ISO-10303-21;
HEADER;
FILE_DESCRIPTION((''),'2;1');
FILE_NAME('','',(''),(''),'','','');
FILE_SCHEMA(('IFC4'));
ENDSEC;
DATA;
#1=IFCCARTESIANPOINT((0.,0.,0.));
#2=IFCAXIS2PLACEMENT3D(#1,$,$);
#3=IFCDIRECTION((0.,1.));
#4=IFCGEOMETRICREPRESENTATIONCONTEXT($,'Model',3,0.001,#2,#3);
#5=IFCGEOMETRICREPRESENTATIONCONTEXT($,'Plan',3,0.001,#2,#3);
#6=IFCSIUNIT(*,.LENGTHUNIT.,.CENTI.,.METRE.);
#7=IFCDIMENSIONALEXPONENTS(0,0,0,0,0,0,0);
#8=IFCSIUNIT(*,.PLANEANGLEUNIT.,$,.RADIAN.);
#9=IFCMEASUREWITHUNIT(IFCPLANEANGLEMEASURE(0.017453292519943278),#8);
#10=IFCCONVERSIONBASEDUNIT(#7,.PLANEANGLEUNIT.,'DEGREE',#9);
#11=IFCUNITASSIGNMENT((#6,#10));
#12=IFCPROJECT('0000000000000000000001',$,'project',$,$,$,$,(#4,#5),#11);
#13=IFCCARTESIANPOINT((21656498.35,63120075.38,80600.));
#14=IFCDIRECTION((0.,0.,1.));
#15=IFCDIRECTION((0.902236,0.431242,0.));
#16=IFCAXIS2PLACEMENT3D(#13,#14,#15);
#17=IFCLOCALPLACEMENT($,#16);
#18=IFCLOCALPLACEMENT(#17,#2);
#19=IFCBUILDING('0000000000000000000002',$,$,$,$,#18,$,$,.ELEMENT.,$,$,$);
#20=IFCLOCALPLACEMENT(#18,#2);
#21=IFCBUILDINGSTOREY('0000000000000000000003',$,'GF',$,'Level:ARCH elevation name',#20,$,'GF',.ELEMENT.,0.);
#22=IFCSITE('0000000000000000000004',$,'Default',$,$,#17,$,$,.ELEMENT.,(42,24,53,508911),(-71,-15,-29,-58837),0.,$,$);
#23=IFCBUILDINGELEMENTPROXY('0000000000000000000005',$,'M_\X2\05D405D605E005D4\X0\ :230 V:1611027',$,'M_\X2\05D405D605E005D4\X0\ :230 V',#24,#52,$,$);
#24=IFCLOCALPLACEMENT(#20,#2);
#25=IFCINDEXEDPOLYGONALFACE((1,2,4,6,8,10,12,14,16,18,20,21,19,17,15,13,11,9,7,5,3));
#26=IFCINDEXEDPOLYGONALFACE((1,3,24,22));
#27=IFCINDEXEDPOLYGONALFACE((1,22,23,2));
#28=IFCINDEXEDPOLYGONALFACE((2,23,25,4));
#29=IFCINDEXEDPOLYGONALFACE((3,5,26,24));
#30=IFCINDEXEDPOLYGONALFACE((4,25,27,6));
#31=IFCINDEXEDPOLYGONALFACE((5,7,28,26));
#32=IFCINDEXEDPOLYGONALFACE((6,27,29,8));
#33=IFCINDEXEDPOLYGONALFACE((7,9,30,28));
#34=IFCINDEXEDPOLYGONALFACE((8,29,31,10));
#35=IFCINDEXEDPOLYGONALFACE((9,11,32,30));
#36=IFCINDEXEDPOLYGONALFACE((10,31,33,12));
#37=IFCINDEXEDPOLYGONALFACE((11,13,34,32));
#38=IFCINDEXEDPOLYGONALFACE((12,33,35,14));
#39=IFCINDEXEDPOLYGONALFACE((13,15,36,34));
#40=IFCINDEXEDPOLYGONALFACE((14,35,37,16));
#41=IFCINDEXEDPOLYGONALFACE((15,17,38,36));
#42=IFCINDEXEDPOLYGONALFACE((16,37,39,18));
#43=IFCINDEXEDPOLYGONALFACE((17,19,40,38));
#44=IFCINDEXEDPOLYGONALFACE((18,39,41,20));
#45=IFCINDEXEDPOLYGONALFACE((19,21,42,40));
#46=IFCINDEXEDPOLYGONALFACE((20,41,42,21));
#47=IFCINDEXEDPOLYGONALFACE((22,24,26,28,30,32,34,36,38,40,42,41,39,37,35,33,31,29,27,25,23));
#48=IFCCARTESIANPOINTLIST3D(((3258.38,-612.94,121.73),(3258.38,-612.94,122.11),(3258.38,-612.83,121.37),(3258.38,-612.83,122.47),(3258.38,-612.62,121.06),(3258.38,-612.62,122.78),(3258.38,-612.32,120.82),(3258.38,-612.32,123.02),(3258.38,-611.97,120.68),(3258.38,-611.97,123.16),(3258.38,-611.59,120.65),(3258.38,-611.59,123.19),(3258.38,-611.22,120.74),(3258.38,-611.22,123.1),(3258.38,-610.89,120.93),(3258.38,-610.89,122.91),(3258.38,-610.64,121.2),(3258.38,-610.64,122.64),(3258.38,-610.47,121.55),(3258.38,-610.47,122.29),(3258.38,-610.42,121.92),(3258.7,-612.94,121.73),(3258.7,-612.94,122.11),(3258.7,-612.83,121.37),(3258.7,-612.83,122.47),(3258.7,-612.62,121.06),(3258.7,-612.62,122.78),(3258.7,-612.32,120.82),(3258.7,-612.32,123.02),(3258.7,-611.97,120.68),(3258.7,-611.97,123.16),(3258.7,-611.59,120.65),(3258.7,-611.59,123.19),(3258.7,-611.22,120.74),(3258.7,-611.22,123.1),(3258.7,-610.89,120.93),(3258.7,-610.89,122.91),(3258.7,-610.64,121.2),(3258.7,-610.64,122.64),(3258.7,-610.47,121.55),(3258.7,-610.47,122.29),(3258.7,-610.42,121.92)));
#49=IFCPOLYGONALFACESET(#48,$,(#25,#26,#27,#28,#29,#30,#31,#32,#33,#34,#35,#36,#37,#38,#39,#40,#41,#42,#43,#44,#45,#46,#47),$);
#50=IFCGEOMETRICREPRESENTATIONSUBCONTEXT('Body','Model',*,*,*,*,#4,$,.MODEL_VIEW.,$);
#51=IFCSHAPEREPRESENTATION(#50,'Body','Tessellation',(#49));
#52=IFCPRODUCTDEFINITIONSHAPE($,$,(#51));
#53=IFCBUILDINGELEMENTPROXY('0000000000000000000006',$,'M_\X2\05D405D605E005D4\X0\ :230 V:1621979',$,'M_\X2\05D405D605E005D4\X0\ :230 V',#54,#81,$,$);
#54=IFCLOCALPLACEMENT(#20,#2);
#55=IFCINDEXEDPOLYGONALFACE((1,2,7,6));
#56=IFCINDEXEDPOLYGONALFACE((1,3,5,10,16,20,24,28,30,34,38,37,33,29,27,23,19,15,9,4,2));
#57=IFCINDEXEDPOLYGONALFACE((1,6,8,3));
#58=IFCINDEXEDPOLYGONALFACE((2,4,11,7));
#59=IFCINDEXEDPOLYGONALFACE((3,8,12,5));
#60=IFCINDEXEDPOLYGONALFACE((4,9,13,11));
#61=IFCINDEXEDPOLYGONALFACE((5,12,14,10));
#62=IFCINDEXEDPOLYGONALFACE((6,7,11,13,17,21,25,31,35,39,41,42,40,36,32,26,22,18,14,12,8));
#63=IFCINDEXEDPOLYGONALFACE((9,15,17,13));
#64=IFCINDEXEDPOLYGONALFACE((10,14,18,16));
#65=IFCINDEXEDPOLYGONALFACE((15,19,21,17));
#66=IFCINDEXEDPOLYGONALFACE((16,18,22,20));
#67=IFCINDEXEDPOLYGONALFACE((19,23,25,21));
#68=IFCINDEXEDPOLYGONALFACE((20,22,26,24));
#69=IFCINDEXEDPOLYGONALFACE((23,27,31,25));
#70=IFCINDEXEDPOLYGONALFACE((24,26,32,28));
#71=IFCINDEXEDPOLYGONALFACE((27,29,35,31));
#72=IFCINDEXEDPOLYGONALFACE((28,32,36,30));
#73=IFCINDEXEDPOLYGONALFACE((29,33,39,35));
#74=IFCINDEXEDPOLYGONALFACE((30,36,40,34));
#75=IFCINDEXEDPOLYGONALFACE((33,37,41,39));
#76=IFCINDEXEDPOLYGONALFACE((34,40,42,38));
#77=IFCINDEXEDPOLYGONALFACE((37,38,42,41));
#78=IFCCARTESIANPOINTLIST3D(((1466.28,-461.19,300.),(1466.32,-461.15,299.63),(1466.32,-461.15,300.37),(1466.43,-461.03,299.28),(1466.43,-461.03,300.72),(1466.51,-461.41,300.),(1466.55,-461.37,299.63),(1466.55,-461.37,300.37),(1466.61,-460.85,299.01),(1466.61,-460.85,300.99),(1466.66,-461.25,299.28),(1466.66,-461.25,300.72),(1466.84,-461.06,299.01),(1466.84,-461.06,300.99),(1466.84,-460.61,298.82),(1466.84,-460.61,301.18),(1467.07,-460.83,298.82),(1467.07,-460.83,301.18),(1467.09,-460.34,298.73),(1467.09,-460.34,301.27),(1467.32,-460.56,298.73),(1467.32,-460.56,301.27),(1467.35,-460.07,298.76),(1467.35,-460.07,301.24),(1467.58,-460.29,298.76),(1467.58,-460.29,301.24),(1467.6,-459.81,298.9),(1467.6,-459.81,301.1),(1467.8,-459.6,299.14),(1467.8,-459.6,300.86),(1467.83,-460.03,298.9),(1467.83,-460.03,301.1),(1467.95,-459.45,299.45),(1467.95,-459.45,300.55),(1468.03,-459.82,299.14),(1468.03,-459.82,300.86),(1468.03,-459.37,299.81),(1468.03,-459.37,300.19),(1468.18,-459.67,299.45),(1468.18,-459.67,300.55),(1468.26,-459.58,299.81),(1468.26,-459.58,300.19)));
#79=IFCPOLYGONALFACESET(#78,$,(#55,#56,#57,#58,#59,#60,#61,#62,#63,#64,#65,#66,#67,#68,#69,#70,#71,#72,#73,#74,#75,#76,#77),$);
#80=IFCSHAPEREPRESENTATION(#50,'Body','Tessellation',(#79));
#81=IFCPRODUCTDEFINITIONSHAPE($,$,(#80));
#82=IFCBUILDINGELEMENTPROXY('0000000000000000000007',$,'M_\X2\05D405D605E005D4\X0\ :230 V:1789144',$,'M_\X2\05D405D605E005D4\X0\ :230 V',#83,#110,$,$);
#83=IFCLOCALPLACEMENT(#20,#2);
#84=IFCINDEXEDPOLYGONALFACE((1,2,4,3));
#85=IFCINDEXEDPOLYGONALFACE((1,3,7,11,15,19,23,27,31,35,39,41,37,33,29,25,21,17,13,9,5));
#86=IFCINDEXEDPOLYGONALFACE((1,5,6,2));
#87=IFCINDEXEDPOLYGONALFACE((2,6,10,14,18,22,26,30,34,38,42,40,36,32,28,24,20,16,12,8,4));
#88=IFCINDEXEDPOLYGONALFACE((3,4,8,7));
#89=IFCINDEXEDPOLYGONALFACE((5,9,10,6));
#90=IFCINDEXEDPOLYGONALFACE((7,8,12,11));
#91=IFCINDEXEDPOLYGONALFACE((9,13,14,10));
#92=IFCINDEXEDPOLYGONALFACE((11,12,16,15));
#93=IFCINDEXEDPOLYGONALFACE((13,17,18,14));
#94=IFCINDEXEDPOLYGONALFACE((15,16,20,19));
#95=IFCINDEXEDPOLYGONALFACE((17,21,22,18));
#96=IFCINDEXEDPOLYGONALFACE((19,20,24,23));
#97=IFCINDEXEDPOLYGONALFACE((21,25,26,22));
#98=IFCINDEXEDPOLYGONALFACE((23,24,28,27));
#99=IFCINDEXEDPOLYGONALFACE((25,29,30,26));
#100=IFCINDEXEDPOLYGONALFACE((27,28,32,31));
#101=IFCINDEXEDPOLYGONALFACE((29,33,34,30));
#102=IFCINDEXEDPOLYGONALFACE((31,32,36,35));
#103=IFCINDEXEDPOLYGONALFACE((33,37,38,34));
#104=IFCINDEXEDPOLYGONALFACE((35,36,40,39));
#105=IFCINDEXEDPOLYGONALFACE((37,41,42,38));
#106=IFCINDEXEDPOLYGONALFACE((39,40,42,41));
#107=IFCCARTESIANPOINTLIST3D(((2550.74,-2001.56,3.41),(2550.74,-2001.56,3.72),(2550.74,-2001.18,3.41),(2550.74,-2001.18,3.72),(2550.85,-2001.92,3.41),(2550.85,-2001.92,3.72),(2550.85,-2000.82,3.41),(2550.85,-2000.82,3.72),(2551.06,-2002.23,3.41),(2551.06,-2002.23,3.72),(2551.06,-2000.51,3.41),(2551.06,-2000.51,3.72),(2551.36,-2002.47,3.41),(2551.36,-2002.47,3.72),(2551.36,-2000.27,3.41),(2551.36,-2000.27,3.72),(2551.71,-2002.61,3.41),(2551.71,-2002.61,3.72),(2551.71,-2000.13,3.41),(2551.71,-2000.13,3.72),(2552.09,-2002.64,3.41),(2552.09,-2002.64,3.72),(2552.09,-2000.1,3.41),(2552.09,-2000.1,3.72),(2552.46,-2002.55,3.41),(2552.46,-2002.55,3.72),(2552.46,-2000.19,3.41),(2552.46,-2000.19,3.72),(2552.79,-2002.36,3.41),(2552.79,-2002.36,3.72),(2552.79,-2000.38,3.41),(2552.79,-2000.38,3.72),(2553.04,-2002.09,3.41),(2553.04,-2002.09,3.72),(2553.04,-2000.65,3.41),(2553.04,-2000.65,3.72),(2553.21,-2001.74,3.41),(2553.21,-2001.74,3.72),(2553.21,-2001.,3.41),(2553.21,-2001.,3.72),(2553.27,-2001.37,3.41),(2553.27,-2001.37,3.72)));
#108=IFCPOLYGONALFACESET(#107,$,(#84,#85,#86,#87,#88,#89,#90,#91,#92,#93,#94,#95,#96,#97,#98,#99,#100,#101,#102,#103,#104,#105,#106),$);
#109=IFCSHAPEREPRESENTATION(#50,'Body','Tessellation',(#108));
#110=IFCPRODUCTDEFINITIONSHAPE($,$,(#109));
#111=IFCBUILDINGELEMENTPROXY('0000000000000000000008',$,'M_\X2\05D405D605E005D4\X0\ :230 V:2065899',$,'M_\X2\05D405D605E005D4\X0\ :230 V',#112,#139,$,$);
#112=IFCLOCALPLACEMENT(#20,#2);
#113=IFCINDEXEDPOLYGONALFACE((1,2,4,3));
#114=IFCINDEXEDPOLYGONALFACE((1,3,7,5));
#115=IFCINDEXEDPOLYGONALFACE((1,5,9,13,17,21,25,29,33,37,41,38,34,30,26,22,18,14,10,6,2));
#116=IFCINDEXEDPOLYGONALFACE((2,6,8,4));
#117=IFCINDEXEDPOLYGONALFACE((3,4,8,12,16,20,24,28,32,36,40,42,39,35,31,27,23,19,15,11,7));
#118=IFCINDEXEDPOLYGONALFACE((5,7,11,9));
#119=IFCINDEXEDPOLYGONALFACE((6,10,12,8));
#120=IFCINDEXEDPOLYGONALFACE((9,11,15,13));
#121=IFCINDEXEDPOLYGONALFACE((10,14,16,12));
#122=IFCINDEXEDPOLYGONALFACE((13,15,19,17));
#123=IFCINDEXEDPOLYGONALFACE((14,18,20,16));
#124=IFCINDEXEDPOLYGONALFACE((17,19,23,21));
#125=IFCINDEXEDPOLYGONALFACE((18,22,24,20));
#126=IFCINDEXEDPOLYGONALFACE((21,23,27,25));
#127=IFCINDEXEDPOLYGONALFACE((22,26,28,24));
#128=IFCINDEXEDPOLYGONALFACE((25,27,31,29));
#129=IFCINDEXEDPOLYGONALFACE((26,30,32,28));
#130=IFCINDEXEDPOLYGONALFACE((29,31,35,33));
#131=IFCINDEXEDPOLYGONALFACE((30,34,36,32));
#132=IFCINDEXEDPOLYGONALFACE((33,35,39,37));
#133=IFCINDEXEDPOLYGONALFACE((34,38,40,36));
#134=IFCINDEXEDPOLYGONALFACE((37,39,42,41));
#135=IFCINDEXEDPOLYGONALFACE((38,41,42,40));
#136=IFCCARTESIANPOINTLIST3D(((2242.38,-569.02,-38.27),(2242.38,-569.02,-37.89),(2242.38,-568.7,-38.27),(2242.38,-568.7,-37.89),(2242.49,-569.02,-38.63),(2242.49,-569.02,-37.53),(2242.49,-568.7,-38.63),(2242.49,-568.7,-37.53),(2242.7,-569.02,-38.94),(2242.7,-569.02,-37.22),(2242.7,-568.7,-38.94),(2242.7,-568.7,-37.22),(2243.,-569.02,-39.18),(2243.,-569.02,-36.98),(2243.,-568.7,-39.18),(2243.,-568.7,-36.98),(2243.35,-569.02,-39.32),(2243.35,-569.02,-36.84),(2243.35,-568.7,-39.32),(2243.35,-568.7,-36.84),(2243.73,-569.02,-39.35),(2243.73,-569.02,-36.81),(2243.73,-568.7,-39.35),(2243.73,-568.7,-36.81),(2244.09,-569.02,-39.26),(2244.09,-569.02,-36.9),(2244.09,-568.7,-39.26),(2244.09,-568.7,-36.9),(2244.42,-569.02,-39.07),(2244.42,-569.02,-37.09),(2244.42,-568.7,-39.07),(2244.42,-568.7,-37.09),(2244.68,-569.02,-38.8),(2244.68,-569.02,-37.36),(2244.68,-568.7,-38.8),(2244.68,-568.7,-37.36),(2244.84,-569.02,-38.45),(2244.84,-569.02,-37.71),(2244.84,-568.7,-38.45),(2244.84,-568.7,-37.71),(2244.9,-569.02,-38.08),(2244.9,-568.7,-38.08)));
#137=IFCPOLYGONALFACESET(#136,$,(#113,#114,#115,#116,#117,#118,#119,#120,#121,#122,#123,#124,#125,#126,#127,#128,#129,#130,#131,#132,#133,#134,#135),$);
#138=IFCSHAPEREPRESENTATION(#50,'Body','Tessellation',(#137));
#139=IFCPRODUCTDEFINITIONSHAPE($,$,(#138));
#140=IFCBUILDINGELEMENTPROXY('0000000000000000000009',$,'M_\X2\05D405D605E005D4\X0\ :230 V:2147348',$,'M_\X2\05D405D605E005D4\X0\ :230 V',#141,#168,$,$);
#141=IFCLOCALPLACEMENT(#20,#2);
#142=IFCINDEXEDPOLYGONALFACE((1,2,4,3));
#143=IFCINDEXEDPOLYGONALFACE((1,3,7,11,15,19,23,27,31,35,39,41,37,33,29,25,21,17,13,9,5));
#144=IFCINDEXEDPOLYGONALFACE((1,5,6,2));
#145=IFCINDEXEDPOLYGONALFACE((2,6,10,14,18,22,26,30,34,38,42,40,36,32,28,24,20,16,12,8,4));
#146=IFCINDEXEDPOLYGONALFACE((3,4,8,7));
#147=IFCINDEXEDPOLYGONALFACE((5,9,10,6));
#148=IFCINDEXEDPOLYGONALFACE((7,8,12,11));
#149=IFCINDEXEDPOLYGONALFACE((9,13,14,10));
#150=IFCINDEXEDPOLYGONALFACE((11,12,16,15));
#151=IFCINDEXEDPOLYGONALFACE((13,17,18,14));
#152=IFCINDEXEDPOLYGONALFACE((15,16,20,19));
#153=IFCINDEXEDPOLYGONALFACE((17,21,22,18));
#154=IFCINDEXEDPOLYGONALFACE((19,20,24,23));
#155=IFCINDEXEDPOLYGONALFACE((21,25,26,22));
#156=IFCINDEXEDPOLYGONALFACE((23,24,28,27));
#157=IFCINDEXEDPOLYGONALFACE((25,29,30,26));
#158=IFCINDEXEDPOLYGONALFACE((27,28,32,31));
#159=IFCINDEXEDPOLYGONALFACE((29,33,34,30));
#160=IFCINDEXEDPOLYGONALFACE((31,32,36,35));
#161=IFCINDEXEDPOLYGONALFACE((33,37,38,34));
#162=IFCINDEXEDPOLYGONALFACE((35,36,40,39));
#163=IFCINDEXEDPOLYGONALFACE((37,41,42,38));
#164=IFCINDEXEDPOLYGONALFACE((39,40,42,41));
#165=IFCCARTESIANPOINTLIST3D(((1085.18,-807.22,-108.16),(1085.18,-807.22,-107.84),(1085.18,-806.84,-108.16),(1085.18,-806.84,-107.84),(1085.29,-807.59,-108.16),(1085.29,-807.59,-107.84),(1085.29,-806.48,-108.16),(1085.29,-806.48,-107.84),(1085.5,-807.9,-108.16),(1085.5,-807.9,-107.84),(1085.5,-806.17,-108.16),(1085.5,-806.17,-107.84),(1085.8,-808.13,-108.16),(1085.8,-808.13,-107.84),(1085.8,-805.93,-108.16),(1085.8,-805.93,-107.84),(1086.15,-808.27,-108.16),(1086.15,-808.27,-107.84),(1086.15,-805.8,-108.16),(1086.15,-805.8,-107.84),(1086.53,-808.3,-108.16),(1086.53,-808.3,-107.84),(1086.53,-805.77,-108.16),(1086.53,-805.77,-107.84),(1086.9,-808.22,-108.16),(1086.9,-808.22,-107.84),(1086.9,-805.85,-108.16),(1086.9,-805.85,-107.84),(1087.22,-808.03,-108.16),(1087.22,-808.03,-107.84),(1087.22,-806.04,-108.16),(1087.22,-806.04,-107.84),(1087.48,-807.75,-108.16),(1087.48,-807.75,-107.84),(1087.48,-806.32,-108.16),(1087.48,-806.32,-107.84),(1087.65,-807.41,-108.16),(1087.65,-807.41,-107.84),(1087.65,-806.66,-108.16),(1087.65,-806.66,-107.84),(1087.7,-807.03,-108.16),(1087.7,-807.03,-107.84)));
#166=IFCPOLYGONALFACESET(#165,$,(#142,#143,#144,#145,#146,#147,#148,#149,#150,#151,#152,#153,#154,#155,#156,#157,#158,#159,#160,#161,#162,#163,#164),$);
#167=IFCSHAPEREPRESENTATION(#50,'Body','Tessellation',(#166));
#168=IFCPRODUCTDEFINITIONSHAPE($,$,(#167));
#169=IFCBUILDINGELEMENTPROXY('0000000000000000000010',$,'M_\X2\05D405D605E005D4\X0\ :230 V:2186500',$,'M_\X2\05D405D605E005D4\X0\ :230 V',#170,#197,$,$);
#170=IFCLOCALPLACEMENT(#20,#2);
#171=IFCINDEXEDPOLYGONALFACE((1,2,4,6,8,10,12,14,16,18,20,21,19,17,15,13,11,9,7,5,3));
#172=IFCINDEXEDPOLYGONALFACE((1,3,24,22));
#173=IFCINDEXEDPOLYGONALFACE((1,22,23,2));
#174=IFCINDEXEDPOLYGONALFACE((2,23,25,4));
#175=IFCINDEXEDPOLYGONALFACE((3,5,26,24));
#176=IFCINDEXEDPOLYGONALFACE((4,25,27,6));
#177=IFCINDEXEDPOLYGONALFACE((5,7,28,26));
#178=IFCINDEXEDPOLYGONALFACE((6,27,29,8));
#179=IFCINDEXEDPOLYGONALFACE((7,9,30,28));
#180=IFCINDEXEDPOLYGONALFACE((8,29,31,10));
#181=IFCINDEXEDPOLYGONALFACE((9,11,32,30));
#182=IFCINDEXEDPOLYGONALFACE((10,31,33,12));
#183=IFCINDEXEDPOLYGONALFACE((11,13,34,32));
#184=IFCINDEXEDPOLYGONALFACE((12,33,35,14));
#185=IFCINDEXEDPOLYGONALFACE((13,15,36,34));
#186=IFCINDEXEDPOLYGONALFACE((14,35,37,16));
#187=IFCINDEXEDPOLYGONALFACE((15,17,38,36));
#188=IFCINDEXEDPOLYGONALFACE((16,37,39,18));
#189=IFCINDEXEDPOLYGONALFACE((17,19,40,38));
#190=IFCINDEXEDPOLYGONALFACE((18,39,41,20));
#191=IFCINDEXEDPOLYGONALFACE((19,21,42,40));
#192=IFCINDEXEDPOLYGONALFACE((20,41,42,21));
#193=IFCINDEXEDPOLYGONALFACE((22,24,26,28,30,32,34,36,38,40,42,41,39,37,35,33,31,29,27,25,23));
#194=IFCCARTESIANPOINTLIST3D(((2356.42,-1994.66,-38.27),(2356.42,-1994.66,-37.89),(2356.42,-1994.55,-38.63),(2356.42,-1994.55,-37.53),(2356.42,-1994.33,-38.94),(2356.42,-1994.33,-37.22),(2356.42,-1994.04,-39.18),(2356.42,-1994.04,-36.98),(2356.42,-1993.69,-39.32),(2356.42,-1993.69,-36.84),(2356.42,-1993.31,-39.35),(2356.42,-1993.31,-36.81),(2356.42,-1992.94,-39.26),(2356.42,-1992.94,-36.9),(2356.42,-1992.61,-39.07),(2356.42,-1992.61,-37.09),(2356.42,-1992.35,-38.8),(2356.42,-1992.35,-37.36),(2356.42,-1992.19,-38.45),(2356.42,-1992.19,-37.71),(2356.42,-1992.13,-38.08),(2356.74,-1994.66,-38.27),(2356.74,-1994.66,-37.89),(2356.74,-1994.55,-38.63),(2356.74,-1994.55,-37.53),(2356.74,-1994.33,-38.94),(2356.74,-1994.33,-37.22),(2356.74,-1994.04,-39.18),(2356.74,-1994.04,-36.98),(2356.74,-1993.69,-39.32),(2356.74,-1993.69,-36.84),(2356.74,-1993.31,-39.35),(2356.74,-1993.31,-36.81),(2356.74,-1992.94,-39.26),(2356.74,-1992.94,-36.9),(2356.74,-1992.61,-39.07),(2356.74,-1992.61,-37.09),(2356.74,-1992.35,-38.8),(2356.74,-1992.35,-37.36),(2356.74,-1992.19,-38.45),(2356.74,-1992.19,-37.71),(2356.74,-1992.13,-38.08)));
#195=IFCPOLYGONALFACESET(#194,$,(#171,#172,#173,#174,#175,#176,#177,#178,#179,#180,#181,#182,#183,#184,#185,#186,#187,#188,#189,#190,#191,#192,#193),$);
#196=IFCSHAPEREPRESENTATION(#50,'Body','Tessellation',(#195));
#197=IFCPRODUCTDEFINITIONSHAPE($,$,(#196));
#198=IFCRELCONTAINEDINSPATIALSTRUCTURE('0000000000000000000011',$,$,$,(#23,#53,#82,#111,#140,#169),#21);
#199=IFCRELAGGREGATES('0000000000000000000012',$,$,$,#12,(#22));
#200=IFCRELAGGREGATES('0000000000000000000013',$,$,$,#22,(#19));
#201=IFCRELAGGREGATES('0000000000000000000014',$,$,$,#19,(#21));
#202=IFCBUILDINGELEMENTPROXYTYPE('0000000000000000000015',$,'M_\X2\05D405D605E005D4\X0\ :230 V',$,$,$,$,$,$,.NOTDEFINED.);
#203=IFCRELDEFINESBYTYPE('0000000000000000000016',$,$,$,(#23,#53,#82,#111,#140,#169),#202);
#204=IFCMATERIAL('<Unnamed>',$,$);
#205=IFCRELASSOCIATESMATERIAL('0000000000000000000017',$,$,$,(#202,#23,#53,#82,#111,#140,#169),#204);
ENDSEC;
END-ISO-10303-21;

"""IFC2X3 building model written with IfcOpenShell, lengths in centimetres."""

from ifc_helpers import new_model, entity, si_unit, converted_unit, direction, frame, frame_2d, origin, place, context, subcontext, project, spatial, circle, extrude, source, transform, mapped, material, type_object, type_shapes, element, save


model = new_model("IFC2X3")

# Units and contexts
model_context = context("Model", 3, precision=0.001, world=origin(), true_north=direction((0.0, 1.0)))
plan_context = context("Plan", 3, precision=0.001, world=origin(), true_north=direction((0.0, 1.0)))
body_context = subcontext(model_context, "Body", "Model", "MODEL_VIEW")
ifc_project = project(units=[si_unit("LENGTHUNIT", "METRE", prefix="CENTI"), converted_unit("PLANEANGLEUNIT", "DEGREE", entity("IfcPlaneAngleMeasure", 0.017453292519943278), si_unit("PLANEANGLEUNIT", "RADIAN"), dimensions=[0, 0, 0, 0, 0, 0, 0])], contexts=[model_context, plan_context])

# Site, building, storey
site_placement = place(None, frame((21656498.35, 63120075.38, 80600.0), z_axis=(0.0, 0.0, 1.0), x_axis=(0.902236, 0.431242, 0.0)))
site = spatial("IfcSite", under=ifc_project, at=site_placement, Name="Default", CompositionType="ELEMENT", RefLatitude=(42, 24, 53, 508911), RefLongitude=(-71, -15, -29, -58837), RefElevation=0.0)
building_placement = place(site_placement, origin())
building = spatial("IfcBuilding", under=site, at=building_placement, CompositionType="ELEMENT")
storey_placement = place(building_placement, origin())
storey = spatial("IfcBuildingStorey", under=building, at=storey_placement, Name="GF", ObjectType="Level:ARCH elevation name", LongName="GF", CompositionType="ELEMENT", Elevation=0.0)

# Building element proxies
ifc_material_1 = material(Name="<Unnamed>")
building_element_proxy_type_1 = type_object("IfcBuildingElementProxyType", Name="M_הזנה :230 V", PredefinedType="NOTDEFINED", material=ifc_material_1)
shared_shape_1 = source(origin(), body_context, "Body", "SweptSolid", [
    extrude(circle(Radius=1.27, at=frame_2d((0.0, 0.0), x_axis=(1.0, 0.0))), origin(), (0.0, 0.0, 1.0), 0.32),
])
type_shapes(building_element_proxy_type_1, [shared_shape_1])
for number, where, z_axis, x_axis, name in (
    (1, (3258.38, -611.69, 121.92), (1.0, 0.0, 0.0), (0.0, 1.0, 0.0), "M_הזנה :230 V:1611027"),
    (2, (1467.16, -460.27, 300.0), (0.722824, -0.691032, 0.0), (-0.691032, -0.722824, 0.0), "M_הזנה :230 V:1621979"),
):
    element("IfcBuildingElementProxy", number, at=place(storey_placement, frame(where, z_axis=z_axis, x_axis=x_axis)), inside=storey, type_object=building_element_proxy_type_1, material=ifc_material_1, Name=name, ObjectType="M_הזנה :230 V", context=body_context, shape_type="MappedRepresentation", body=[
        mapped(shared_shape_1, transform((0.0, 0.0, 0.0), scale=1.0)),
    ])
proxy_1_placement = place(storey_placement, frame((2552.0, -2001.37, 3.41)))
element("IfcBuildingElementProxy", 3, at=proxy_1_placement, inside=storey, type_object=building_element_proxy_type_1, material=ifc_material_1, Name="M_הזנה :230 V:1789144", ObjectType="M_הזנה :230 V", context=body_context, shape_type="MappedRepresentation", body=[
    mapped(shared_shape_1, transform((0.0, 0.0, 0.0), scale=1.0)),
])
for number, where, z_axis, x_axis, name in (
    (4, (2243.63, -568.7, -38.08), (0.0, -1.0, 0.0), (1.0, 0.0, 0.0), "M_הזנה :230 V:2065899"),
):
    element("IfcBuildingElementProxy", number, at=place(storey_placement, frame(where, z_axis=z_axis, x_axis=x_axis)), inside=storey, type_object=building_element_proxy_type_1, material=ifc_material_1, Name=name, ObjectType="M_הזנה :230 V", context=body_context, shape_type="MappedRepresentation", body=[
        mapped(shared_shape_1, transform((0.0, 0.0, 0.0), scale=1.0)),
    ])
proxy_2_placement = place(storey_placement, frame((1086.43, -807.03, -108.16)))
element("IfcBuildingElementProxy", 5, at=proxy_2_placement, inside=storey, type_object=building_element_proxy_type_1, material=ifc_material_1, Name="M_הזנה :230 V:2147348", ObjectType="M_הזנה :230 V", context=body_context, shape_type="MappedRepresentation", body=[
    mapped(shared_shape_1, transform((0.0, 0.0, 0.0), scale=1.0)),
])
for number, where, z_axis, x_axis, name in (
    (6, (2356.74, -1993.4, -38.08), (-1.0, 0.0, 0.0), (0.0, 1.0, 0.0), "M_הזנה :230 V:2186500"),
):
    element("IfcBuildingElementProxy", number, at=place(storey_placement, frame(where, z_axis=z_axis, x_axis=x_axis)), inside=storey, type_object=building_element_proxy_type_1, material=ifc_material_1, Name=name, ObjectType="M_הזנה :230 V", context=body_context, shape_type="MappedRepresentation", body=[
        mapped(shared_shape_1, transform((0.0, 0.0, 0.0), scale=1.0)),
    ])

save(model, "model.ifc")
